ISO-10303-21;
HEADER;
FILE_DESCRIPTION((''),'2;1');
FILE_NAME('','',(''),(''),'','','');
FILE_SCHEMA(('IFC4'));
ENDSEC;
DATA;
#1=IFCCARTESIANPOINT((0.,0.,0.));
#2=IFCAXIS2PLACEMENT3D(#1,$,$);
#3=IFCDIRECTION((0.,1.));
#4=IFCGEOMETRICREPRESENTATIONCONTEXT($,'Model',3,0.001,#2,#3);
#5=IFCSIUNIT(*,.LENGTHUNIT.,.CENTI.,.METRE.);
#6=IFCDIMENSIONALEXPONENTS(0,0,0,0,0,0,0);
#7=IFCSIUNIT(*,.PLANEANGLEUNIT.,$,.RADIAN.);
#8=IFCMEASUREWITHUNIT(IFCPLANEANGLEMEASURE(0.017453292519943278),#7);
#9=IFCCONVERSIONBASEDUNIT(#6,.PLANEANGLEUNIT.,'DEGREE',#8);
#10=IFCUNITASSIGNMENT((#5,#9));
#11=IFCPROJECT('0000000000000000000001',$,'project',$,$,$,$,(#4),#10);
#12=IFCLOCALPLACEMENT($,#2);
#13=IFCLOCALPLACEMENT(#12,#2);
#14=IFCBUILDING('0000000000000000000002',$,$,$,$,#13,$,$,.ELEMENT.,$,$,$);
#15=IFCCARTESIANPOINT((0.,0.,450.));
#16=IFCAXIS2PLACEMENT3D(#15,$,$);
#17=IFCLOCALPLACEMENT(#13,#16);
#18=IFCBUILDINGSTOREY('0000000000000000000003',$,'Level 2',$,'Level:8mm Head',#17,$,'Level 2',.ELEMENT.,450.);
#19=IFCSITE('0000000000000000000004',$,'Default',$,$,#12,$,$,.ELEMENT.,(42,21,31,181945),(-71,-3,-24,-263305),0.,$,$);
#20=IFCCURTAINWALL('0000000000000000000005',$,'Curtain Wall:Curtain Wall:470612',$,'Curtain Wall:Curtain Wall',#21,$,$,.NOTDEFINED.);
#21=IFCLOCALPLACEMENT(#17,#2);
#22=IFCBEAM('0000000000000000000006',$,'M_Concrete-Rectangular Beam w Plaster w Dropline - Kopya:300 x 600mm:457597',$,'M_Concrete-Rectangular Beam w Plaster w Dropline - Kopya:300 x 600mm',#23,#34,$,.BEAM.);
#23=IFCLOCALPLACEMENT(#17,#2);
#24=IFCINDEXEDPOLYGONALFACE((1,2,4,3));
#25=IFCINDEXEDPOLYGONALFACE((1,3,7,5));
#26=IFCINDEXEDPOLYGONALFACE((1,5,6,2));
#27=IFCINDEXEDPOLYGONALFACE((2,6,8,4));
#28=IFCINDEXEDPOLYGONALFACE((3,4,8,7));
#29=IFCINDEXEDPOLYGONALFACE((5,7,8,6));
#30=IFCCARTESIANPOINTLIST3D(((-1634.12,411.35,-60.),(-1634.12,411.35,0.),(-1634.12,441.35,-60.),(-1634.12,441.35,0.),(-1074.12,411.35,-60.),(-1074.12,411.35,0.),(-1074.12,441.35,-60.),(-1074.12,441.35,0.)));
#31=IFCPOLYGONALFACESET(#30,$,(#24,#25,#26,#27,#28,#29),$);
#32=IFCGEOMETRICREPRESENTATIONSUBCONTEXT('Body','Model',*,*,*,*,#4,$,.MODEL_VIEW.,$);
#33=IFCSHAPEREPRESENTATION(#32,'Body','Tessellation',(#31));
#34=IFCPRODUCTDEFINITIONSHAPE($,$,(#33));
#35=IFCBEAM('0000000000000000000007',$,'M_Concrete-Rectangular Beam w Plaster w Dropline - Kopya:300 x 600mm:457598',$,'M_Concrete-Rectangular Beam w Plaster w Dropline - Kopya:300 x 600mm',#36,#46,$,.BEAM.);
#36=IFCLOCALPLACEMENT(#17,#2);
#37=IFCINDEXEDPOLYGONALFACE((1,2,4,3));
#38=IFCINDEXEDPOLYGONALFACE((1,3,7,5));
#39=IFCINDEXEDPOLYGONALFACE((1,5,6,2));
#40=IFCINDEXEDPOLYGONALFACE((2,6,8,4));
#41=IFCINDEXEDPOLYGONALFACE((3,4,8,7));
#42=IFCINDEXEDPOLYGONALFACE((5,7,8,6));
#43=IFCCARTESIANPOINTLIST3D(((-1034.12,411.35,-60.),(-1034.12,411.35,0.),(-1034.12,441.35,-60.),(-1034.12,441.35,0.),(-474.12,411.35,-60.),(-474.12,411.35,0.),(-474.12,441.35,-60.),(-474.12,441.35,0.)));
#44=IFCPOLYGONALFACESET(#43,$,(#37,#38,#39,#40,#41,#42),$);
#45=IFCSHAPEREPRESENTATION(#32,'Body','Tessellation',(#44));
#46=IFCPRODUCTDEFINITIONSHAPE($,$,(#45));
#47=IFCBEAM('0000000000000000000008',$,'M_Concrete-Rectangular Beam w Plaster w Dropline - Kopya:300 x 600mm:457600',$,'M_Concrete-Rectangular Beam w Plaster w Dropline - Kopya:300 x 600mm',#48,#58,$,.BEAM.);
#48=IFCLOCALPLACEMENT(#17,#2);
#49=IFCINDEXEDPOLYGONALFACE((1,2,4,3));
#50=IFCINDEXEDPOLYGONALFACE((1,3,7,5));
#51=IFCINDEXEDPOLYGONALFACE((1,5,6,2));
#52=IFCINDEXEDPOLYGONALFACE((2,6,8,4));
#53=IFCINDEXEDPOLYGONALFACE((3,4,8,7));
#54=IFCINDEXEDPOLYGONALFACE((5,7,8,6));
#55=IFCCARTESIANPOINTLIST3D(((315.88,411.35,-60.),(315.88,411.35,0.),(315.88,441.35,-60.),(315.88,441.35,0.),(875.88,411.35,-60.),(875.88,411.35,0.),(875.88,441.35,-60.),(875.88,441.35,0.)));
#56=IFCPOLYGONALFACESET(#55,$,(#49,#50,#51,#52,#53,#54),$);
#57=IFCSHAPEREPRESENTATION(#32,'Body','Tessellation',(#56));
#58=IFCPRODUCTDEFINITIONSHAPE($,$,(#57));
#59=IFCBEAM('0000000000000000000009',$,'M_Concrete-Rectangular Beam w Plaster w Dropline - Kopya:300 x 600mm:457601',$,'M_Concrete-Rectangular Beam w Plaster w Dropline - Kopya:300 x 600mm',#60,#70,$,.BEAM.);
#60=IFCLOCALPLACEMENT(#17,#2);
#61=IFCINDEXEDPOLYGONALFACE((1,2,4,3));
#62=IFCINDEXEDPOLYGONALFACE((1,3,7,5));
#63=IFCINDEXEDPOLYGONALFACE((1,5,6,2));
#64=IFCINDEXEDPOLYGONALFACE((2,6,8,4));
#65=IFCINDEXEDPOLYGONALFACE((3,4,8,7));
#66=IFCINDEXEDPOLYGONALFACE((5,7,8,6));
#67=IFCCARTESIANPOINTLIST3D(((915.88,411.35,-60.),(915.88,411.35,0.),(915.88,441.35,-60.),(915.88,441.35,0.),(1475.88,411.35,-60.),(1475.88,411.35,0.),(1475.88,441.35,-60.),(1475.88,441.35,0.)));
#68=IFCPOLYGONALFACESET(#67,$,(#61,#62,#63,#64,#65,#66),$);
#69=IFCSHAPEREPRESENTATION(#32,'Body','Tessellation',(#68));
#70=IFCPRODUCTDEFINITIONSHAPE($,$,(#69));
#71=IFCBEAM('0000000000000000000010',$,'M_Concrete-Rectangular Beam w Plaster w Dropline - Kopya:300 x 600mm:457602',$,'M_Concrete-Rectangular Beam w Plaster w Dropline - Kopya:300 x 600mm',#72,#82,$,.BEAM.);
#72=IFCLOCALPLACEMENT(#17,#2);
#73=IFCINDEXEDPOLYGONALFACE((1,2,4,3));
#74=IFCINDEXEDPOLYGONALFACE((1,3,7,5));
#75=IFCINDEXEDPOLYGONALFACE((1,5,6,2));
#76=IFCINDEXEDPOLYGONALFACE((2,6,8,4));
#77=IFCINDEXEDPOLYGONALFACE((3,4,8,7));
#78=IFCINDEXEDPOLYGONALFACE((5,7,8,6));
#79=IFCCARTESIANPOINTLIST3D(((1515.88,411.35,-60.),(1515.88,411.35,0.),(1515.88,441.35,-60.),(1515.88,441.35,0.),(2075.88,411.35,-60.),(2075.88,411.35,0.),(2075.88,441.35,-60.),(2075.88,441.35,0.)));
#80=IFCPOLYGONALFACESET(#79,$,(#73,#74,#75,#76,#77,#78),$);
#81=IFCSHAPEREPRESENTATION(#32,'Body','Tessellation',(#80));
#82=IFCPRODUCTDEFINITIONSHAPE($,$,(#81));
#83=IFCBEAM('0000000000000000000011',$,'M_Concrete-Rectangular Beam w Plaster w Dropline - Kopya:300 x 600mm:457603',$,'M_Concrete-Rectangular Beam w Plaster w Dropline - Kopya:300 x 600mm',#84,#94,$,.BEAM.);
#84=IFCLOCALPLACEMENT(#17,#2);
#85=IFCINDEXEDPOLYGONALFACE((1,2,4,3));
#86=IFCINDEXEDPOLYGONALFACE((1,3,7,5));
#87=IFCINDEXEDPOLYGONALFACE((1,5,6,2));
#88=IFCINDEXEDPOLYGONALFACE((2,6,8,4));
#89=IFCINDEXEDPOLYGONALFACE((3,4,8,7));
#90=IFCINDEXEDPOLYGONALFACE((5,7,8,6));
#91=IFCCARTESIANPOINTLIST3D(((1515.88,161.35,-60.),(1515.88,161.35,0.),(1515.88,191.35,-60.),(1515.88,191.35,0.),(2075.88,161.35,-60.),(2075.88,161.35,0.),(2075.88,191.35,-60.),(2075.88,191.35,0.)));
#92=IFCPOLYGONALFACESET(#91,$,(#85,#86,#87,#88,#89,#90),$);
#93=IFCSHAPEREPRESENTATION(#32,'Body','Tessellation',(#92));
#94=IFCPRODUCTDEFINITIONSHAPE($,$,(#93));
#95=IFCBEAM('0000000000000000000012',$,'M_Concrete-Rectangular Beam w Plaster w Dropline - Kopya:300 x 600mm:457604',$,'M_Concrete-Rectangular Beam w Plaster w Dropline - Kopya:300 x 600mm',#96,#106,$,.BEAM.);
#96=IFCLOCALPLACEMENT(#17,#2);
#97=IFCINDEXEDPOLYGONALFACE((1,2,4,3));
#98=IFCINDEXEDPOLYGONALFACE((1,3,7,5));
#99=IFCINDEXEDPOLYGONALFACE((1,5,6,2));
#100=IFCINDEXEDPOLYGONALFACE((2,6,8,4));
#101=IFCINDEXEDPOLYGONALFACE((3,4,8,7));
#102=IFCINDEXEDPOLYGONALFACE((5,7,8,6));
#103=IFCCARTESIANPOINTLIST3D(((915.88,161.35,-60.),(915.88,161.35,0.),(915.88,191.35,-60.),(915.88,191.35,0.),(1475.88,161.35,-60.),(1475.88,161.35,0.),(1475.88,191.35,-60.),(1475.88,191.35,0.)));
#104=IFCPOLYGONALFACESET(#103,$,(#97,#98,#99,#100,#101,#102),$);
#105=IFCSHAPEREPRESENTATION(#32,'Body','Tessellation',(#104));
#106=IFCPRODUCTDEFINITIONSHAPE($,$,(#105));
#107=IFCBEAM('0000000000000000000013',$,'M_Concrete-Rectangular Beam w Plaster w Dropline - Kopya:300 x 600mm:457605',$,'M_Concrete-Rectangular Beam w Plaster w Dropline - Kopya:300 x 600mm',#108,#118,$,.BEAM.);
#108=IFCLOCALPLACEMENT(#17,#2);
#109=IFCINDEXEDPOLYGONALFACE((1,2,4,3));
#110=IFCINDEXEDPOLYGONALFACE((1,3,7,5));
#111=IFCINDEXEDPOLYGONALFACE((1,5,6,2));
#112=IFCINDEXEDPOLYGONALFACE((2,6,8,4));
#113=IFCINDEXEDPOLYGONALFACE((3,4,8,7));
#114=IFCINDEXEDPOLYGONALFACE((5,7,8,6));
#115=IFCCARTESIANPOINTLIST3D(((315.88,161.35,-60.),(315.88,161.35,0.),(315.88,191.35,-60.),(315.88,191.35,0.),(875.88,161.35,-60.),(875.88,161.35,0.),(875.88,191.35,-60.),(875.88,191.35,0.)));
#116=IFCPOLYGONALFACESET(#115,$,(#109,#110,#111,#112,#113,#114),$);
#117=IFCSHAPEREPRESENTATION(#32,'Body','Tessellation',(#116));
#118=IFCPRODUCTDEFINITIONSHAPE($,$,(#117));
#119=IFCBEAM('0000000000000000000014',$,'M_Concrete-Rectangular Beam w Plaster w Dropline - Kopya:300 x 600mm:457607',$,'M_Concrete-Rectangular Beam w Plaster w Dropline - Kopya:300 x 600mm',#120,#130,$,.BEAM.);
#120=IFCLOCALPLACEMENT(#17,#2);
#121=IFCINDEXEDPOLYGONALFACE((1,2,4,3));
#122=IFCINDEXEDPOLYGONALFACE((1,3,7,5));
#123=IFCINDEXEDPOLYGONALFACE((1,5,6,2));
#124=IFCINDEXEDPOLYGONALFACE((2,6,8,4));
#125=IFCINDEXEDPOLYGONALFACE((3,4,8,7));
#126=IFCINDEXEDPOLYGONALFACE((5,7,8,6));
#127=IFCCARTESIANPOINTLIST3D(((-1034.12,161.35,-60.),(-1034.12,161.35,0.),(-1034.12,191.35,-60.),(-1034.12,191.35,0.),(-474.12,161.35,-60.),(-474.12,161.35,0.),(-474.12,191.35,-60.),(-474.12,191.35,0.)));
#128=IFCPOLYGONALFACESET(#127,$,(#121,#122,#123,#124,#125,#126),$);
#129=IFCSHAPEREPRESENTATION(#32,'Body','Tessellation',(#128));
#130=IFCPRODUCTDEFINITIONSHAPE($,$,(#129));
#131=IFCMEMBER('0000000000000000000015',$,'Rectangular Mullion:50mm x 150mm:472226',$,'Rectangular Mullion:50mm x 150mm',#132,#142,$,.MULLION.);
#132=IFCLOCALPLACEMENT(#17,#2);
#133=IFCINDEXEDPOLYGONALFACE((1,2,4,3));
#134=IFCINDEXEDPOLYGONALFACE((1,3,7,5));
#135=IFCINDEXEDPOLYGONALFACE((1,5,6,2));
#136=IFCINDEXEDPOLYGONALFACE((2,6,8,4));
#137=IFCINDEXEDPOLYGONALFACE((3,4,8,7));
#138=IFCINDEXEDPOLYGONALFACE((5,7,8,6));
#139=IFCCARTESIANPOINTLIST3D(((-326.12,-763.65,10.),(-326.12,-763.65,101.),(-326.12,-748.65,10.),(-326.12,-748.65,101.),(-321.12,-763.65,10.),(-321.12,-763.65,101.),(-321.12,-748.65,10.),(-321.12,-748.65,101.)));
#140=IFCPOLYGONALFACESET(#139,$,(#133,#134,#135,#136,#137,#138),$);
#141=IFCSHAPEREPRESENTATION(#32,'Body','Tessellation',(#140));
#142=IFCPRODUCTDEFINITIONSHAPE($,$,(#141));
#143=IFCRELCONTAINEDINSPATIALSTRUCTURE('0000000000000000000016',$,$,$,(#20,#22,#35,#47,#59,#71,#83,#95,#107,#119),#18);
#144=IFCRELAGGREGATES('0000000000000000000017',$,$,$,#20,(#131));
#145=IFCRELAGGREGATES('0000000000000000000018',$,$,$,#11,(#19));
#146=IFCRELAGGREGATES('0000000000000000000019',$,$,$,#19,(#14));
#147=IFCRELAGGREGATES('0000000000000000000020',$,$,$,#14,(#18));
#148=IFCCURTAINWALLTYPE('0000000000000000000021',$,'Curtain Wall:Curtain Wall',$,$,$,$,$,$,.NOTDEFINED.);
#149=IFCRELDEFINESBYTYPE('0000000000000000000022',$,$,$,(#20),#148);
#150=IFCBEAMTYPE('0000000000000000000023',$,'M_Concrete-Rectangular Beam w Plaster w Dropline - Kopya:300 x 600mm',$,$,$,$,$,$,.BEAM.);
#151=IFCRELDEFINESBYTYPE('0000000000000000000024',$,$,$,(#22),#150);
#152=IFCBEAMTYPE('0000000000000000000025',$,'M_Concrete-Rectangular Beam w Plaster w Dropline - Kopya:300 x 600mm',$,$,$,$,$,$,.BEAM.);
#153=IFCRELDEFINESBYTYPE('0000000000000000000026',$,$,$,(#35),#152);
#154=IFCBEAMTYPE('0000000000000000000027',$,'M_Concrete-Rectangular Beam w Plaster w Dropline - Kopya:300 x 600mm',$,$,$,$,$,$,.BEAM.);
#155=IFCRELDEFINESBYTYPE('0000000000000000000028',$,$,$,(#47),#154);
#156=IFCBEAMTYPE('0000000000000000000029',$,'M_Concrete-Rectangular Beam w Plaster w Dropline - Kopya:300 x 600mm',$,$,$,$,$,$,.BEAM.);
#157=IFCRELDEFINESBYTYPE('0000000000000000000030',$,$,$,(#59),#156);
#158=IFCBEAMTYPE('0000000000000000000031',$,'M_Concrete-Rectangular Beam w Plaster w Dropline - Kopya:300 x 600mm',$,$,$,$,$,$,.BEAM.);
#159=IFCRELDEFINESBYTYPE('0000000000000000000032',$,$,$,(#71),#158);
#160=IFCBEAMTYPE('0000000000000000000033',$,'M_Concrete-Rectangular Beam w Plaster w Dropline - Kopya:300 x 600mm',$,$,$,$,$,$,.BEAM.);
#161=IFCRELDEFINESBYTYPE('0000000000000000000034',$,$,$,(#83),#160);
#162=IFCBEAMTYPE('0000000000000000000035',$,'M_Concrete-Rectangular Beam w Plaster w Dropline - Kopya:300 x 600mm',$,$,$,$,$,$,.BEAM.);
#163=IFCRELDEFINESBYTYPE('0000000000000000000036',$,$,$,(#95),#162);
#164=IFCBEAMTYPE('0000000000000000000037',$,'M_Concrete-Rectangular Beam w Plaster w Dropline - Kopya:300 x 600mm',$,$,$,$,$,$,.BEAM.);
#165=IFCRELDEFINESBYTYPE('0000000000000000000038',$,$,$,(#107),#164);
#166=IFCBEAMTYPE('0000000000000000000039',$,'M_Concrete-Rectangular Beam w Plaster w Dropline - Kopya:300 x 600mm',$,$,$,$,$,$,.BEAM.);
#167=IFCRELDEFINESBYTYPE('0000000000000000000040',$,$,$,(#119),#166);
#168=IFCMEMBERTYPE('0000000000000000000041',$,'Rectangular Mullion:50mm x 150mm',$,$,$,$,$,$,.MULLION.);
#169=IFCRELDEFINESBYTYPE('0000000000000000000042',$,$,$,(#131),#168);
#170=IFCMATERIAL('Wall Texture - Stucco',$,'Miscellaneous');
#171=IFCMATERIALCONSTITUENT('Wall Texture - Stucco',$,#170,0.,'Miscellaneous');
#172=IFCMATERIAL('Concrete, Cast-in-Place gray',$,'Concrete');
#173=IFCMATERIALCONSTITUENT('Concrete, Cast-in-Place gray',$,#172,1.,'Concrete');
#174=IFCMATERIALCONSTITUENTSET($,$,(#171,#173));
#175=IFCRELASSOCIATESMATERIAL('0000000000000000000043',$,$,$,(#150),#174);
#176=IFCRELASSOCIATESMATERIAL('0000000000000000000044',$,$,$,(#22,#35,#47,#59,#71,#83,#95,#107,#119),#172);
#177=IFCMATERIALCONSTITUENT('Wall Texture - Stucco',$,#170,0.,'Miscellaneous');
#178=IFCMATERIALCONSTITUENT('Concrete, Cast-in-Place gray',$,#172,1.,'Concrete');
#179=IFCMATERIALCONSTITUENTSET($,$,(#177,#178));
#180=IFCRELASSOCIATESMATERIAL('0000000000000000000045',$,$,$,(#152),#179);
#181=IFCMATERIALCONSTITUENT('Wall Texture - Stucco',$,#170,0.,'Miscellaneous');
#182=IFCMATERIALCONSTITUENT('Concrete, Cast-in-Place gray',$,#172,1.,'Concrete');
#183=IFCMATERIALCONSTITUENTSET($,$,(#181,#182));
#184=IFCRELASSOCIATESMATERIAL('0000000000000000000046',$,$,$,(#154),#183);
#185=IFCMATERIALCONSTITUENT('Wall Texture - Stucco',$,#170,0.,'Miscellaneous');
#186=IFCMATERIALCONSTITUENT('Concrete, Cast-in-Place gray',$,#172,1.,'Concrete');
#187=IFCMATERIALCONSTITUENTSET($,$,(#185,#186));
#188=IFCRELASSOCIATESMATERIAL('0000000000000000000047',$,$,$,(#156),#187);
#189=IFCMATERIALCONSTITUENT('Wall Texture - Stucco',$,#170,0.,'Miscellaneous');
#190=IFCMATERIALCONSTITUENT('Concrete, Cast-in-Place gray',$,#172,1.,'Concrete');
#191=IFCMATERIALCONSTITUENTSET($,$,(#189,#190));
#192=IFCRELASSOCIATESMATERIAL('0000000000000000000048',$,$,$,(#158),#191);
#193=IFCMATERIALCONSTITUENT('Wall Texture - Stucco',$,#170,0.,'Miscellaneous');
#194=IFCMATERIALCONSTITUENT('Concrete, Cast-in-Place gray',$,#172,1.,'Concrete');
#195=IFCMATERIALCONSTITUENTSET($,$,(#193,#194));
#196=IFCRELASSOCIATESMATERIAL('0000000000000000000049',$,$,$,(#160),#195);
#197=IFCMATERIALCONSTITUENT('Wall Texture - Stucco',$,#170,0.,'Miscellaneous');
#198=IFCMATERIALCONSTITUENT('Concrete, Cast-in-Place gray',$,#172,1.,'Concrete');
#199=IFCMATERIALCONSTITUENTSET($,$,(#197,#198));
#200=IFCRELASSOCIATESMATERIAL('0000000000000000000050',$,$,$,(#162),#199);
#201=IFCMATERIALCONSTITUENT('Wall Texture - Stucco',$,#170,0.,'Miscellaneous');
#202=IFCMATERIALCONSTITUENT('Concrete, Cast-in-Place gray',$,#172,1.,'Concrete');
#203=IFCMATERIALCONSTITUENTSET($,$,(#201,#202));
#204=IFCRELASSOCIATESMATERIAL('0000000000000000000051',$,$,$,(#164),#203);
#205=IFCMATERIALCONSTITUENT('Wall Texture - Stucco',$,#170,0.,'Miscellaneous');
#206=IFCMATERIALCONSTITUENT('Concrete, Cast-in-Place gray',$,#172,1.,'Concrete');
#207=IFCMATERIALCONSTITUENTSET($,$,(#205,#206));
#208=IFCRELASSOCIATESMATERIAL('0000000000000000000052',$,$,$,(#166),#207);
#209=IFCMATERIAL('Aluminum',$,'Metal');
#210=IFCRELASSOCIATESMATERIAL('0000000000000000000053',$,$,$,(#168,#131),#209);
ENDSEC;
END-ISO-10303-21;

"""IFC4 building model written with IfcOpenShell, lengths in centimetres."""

from ifc_helpers import new_model, entity, si_unit, converted_unit, direction, frame, origin, place, context, subcontext, project, spatial, indexed_curve, outline, extrude, source, transform, mapped, material, constituent, constituent_set, type_object, type_shapes, element, aggregate, save


model = new_model("IFC4")

# Units and contexts
model_context = context("Model", 3, precision=0.001, world=origin(), true_north=direction((0.0, 1.0)))
body_context = subcontext(model_context, "Body", "Model", "MODEL_VIEW")
ifc_project = project(units=[si_unit("LENGTHUNIT", "METRE", prefix="CENTI"), converted_unit("PLANEANGLEUNIT", "DEGREE", entity("IfcPlaneAngleMeasure", 0.017453292519943278), si_unit("PLANEANGLEUNIT", "RADIAN"), dimensions=[0, 0, 0, 0, 0, 0, 0])], contexts=[model_context])

# Site, building, storey
site_placement = place(None, origin())
site = spatial("IfcSite", under=ifc_project, at=site_placement, Name="Default", CompositionType="ELEMENT", RefLatitude=(42, 21, 31, 181945), RefLongitude=(-71, -3, -24, -263305), RefElevation=0.0)
building_placement = place(site_placement, origin())
building = spatial("IfcBuilding", under=site, at=building_placement, CompositionType="ELEMENT")
storey_placement = place(building_placement, frame((0.0, 0.0, 450.0)))
storey = spatial("IfcBuildingStorey", under=building, at=storey_placement, Name="Level 2", ObjectType="Level:8mm Head", LongName="Level 2", CompositionType="ELEMENT", Elevation=450.0)

# Curtain wall
curtain_wall_type = type_object("IfcCurtainWallType", Name="Curtain Wall:Curtain Wall", PredefinedType="NOTDEFINED")
curtain_wall_placement = place(storey_placement, frame((0.0, 0.0, -450.0)))
curtain_wall = element("IfcCurtainWall", 1, at=curtain_wall_placement, inside=storey, type_object=curtain_wall_type, Name="Curtain Wall:Curtain Wall:470612", ObjectType="Curtain Wall:Curtain Wall", PredefinedType="NOTDEFINED")
ifc_material_1 = material(Name="Aluminum", Category="Metal")

# Beams
ifc_material_2 = material(Name="Concrete, Cast-in-Place gray", Category="Concrete")
ifc_material_3 = material(Name="Wall Texture - Stucco", Category="Miscellaneous")
ifc_constituent_1 = constituent(ifc_material_3, Name="Wall Texture - Stucco", Category="Miscellaneous", fraction=0.0)
ifc_constituent_2 = constituent(ifc_material_2, Name="Concrete, Cast-in-Place gray", Category="Concrete", fraction=1.0)
ifc_constituent_set_1 = constituent_set(constituents=[ifc_constituent_1, ifc_constituent_2])
beam_type_1 = type_object("IfcBeamType", Name="M_Concrete-Rectangular Beam w Plaster w Dropline - Kopya:300 x 600mm", PredefinedType="BEAM", material=ifc_constituent_set_1)
shared_shape_1 = source(origin(), body_context, "Body", "SweptSolid", [
    extrude(outline(indexed_curve([(-30.0, -15.0), (30.0, -15.0), (30.0, 15.0), (-30.0, 15.0), (-30.0, -15.0)], self_intersect=False)), frame((-1634.12, 426.35, 420.0), z_axis=(1.0, 0.0, 0.0), x_axis=(0.0, 0.0, -1.0)), (0.0, 0.0, 1.0), 560.0),
])
type_shapes(beam_type_1, [shared_shape_1])
beam_1_placement = place(storey_placement, frame((0.0, 0.0, -450.0)))
element("IfcBeam", 2, at=beam_1_placement, inside=storey, type_object=beam_type_1, material=ifc_material_2, Name="M_Concrete-Rectangular Beam w Plaster w Dropline - Kopya:300 x 600mm:457597", ObjectType="M_Concrete-Rectangular Beam w Plaster w Dropline - Kopya:300 x 600mm", PredefinedType="BEAM", context=body_context, shape_type="MappedRepresentation", body=[
    mapped(shared_shape_1, transform((0.0, 0.0, 0.0), scale=1.0)),
])
ifc_constituent_3 = constituent(ifc_material_3, Name="Wall Texture - Stucco", Category="Miscellaneous", fraction=0.0)
ifc_constituent_4 = constituent(ifc_material_2, Name="Concrete, Cast-in-Place gray", Category="Concrete", fraction=1.0)
ifc_constituent_set_2 = constituent_set(constituents=[ifc_constituent_3, ifc_constituent_4])
beam_type_2 = type_object("IfcBeamType", Name="M_Concrete-Rectangular Beam w Plaster w Dropline - Kopya:300 x 600mm", PredefinedType="BEAM", material=ifc_constituent_set_2)
shared_shape_2 = source(origin(), body_context, "Body", "SweptSolid", [
    extrude(outline(indexed_curve([(-30.0, -15.0), (30.0, -15.0), (30.0, 15.0), (-30.0, 15.0), (-30.0, -15.0)], self_intersect=False)), frame((-1034.12, 426.35, 420.0), z_axis=(1.0, 0.0, 0.0), x_axis=(0.0, 0.0, -1.0)), (0.0, 0.0, 1.0), 560.0),
])
type_shapes(beam_type_2, [shared_shape_2])
beam_2_placement = place(storey_placement, frame((0.0, 0.0, -450.0)))
element("IfcBeam", 3, at=beam_2_placement, inside=storey, type_object=beam_type_2, material=ifc_material_2, Name="M_Concrete-Rectangular Beam w Plaster w Dropline - Kopya:300 x 600mm:457598", ObjectType="M_Concrete-Rectangular Beam w Plaster w Dropline - Kopya:300 x 600mm", PredefinedType="BEAM", context=body_context, shape_type="MappedRepresentation", body=[
    mapped(shared_shape_2, transform((0.0, 0.0, 0.0), scale=1.0)),
])
ifc_constituent_5 = constituent(ifc_material_3, Name="Wall Texture - Stucco", Category="Miscellaneous", fraction=0.0)
ifc_constituent_6 = constituent(ifc_material_2, Name="Concrete, Cast-in-Place gray", Category="Concrete", fraction=1.0)
ifc_constituent_set_3 = constituent_set(constituents=[ifc_constituent_5, ifc_constituent_6])
beam_type_3 = type_object("IfcBeamType", Name="M_Concrete-Rectangular Beam w Plaster w Dropline - Kopya:300 x 600mm", PredefinedType="BEAM", material=ifc_constituent_set_3)
shared_shape_3 = source(origin(), body_context, "Body", "SweptSolid", [
    extrude(outline(indexed_curve([(-30.0, -15.0), (30.0, -15.0), (30.0, 15.0), (-30.0, 15.0), (-30.0, -15.0)], self_intersect=False)), frame((315.88, 426.35, 420.0), z_axis=(1.0, 0.0, 0.0), x_axis=(0.0, 0.0, -1.0)), (0.0, 0.0, 1.0), 560.0),
])
type_shapes(beam_type_3, [shared_shape_3])
beam_3_placement = place(storey_placement, frame((0.0, 0.0, -450.0)))
element("IfcBeam", 4, at=beam_3_placement, inside=storey, type_object=beam_type_3, material=ifc_material_2, Name="M_Concrete-Rectangular Beam w Plaster w Dropline - Kopya:300 x 600mm:457600", ObjectType="M_Concrete-Rectangular Beam w Plaster w Dropline - Kopya:300 x 600mm", PredefinedType="BEAM", context=body_context, shape_type="MappedRepresentation", body=[
    mapped(shared_shape_3, transform((0.0, 0.0, 0.0), scale=1.0)),
])
ifc_constituent_7 = constituent(ifc_material_3, Name="Wall Texture - Stucco", Category="Miscellaneous", fraction=0.0)
ifc_constituent_8 = constituent(ifc_material_2, Name="Concrete, Cast-in-Place gray", Category="Concrete", fraction=1.0)
ifc_constituent_set_4 = constituent_set(constituents=[ifc_constituent_7, ifc_constituent_8])
beam_type_4 = type_object("IfcBeamType", Name="M_Concrete-Rectangular Beam w Plaster w Dropline - Kopya:300 x 600mm", PredefinedType="BEAM", material=ifc_constituent_set_4)
shared_shape_4 = source(origin(), body_context, "Body", "SweptSolid", [
    extrude(outline(indexed_curve([(-30.0, -15.0), (30.0, -15.0), (30.0, 15.0), (-30.0, 15.0), (-30.0, -15.0)], self_intersect=False)), frame((915.88, 426.35, 420.0), z_axis=(1.0, 0.0, 0.0), x_axis=(0.0, 0.0, -1.0)), (0.0, 0.0, 1.0), 560.0),
])
type_shapes(beam_type_4, [shared_shape_4])
beam_4_placement = place(storey_placement, frame((0.0, 0.0, -450.0)))
element("IfcBeam", 5, at=beam_4_placement, inside=storey, type_object=beam_type_4, material=ifc_material_2, Name="M_Concrete-Rectangular Beam w Plaster w Dropline - Kopya:300 x 600mm:457601", ObjectType="M_Concrete-Rectangular Beam w Plaster w Dropline - Kopya:300 x 600mm", PredefinedType="BEAM", context=body_context, shape_type="MappedRepresentation", body=[
    mapped(shared_shape_4, transform((0.0, 0.0, 0.0), scale=1.0)),
])
ifc_constituent_9 = constituent(ifc_material_3, Name="Wall Texture - Stucco", Category="Miscellaneous", fraction=0.0)
ifc_constituent_10 = constituent(ifc_material_2, Name="Concrete, Cast-in-Place gray", Category="Concrete", fraction=1.0)
ifc_constituent_set_5 = constituent_set(constituents=[ifc_constituent_9, ifc_constituent_10])
beam_type_5 = type_object("IfcBeamType", Name="M_Concrete-Rectangular Beam w Plaster w Dropline - Kopya:300 x 600mm", PredefinedType="BEAM", material=ifc_constituent_set_5)
shared_shape_5 = source(origin(), body_context, "Body", "SweptSolid", [
    extrude(outline(indexed_curve([(-30.0, -15.0), (30.0, -15.0), (30.0, 15.0), (-30.0, 15.0), (-30.0, -15.0)], self_intersect=False)), frame((1515.88, 426.35, 420.0), z_axis=(1.0, 0.0, 0.0), x_axis=(0.0, 0.0, -1.0)), (0.0, 0.0, 1.0), 560.0),
])
type_shapes(beam_type_5, [shared_shape_5])
beam_5_placement = place(storey_placement, frame((0.0, 0.0, -450.0)))
element("IfcBeam", 6, at=beam_5_placement, inside=storey, type_object=beam_type_5, material=ifc_material_2, Name="M_Concrete-Rectangular Beam w Plaster w Dropline - Kopya:300 x 600mm:457602", ObjectType="M_Concrete-Rectangular Beam w Plaster w Dropline - Kopya:300 x 600mm", PredefinedType="BEAM", context=body_context, shape_type="MappedRepresentation", body=[
    mapped(shared_shape_5, transform((0.0, 0.0, 0.0), scale=1.0)),
])
ifc_constituent_11 = constituent(ifc_material_3, Name="Wall Texture - Stucco", Category="Miscellaneous", fraction=0.0)
ifc_constituent_12 = constituent(ifc_material_2, Name="Concrete, Cast-in-Place gray", Category="Concrete", fraction=1.0)
ifc_constituent_set_6 = constituent_set(constituents=[ifc_constituent_11, ifc_constituent_12])
beam_type_6 = type_object("IfcBeamType", Name="M_Concrete-Rectangular Beam w Plaster w Dropline - Kopya:300 x 600mm", PredefinedType="BEAM", material=ifc_constituent_set_6)
shared_shape_6 = source(origin(), body_context, "Body", "SweptSolid", [
    extrude(outline(indexed_curve([(-30.0, -15.0), (30.0, -15.0), (30.0, 15.0), (-30.0, 15.0), (-30.0, -15.0)], self_intersect=False)), frame((2075.88, 176.35, 420.0), z_axis=(-1.0, 0.0, 0.0), x_axis=(0.0, 0.0, -1.0)), (0.0, 0.0, 1.0), 560.0),
])
type_shapes(beam_type_6, [shared_shape_6])
beam_6_placement = place(storey_placement, frame((0.0, 0.0, -450.0)))
element("IfcBeam", 7, at=beam_6_placement, inside=storey, type_object=beam_type_6, material=ifc_material_2, Name="M_Concrete-Rectangular Beam w Plaster w Dropline - Kopya:300 x 600mm:457603", ObjectType="M_Concrete-Rectangular Beam w Plaster w Dropline - Kopya:300 x 600mm", PredefinedType="BEAM", context=body_context, shape_type="MappedRepresentation", body=[
    mapped(shared_shape_6, transform((0.0, 0.0, 0.0), scale=1.0)),
])
ifc_constituent_13 = constituent(ifc_material_3, Name="Wall Texture - Stucco", Category="Miscellaneous", fraction=0.0)
ifc_constituent_14 = constituent(ifc_material_2, Name="Concrete, Cast-in-Place gray", Category="Concrete", fraction=1.0)
ifc_constituent_set_7 = constituent_set(constituents=[ifc_constituent_13, ifc_constituent_14])
beam_type_7 = type_object("IfcBeamType", Name="M_Concrete-Rectangular Beam w Plaster w Dropline - Kopya:300 x 600mm", PredefinedType="BEAM", material=ifc_constituent_set_7)
shared_shape_7 = source(origin(), body_context, "Body", "SweptSolid", [
    extrude(outline(indexed_curve([(-30.0, -15.0), (30.0, -15.0), (30.0, 15.0), (-30.0, 15.0), (-30.0, -15.0)], self_intersect=False)), frame((1475.88, 176.35, 420.0), z_axis=(-1.0, 0.0, 0.0), x_axis=(0.0, 0.0, -1.0)), (0.0, 0.0, 1.0), 560.0),
])
type_shapes(beam_type_7, [shared_shape_7])
beam_7_placement = place(storey_placement, frame((0.0, 0.0, -450.0)))
element("IfcBeam", 8, at=beam_7_placement, inside=storey, type_object=beam_type_7, material=ifc_material_2, Name="M_Concrete-Rectangular Beam w Plaster w Dropline - Kopya:300 x 600mm:457604", ObjectType="M_Concrete-Rectangular Beam w Plaster w Dropline - Kopya:300 x 600mm", PredefinedType="BEAM", context=body_context, shape_type="MappedRepresentation", body=[
    mapped(shared_shape_7, transform((0.0, 0.0, 0.0), scale=1.0)),
])
ifc_constituent_15 = constituent(ifc_material_3, Name="Wall Texture - Stucco", Category="Miscellaneous", fraction=0.0)
ifc_constituent_16 = constituent(ifc_material_2, Name="Concrete, Cast-in-Place gray", Category="Concrete", fraction=1.0)
ifc_constituent_set_8 = constituent_set(constituents=[ifc_constituent_15, ifc_constituent_16])
beam_type_8 = type_object("IfcBeamType", Name="M_Concrete-Rectangular Beam w Plaster w Dropline - Kopya:300 x 600mm", PredefinedType="BEAM", material=ifc_constituent_set_8)
shared_shape_8 = source(origin(), body_context, "Body", "SweptSolid", [
    extrude(outline(indexed_curve([(-30.0, -15.0), (30.0, -15.0), (30.0, 15.0), (-30.0, 15.0), (-30.0, -15.0)], self_intersect=False)), frame((875.88, 176.35, 420.0), z_axis=(-1.0, 0.0, 0.0), x_axis=(0.0, 0.0, -1.0)), (0.0, 0.0, 1.0), 560.0),
])
type_shapes(beam_type_8, [shared_shape_8])
beam_8_placement = place(storey_placement, frame((0.0, 0.0, -450.0)))
element("IfcBeam", 9, at=beam_8_placement, inside=storey, type_object=beam_type_8, material=ifc_material_2, Name="M_Concrete-Rectangular Beam w Plaster w Dropline - Kopya:300 x 600mm:457605", ObjectType="M_Concrete-Rectangular Beam w Plaster w Dropline - Kopya:300 x 600mm", PredefinedType="BEAM", context=body_context, shape_type="MappedRepresentation", body=[
    mapped(shared_shape_8, transform((0.0, 0.0, 0.0), scale=1.0)),
])
ifc_constituent_17 = constituent(ifc_material_3, Name="Wall Texture - Stucco", Category="Miscellaneous", fraction=0.0)
ifc_constituent_18 = constituent(ifc_material_2, Name="Concrete, Cast-in-Place gray", Category="Concrete", fraction=1.0)
ifc_constituent_set_9 = constituent_set(constituents=[ifc_constituent_17, ifc_constituent_18])
beam_type_9 = type_object("IfcBeamType", Name="M_Concrete-Rectangular Beam w Plaster w Dropline - Kopya:300 x 600mm", PredefinedType="BEAM", material=ifc_constituent_set_9)
shared_shape_9 = source(origin(), body_context, "Body", "SweptSolid", [
    extrude(outline(indexed_curve([(-30.0, -15.0), (30.0, -15.0), (30.0, 15.0), (-30.0, 15.0), (-30.0, -15.0)], self_intersect=False)), frame((-474.12, 176.35, 420.0), z_axis=(-1.0, 0.0, 0.0), x_axis=(0.0, 0.0, -1.0)), (0.0, 0.0, 1.0), 560.0),
])
type_shapes(beam_type_9, [shared_shape_9])
beam_9_placement = place(storey_placement, frame((0.0, 0.0, -450.0)))
element("IfcBeam", 10, at=beam_9_placement, inside=storey, type_object=beam_type_9, material=ifc_material_2, Name="M_Concrete-Rectangular Beam w Plaster w Dropline - Kopya:300 x 600mm:457607", ObjectType="M_Concrete-Rectangular Beam w Plaster w Dropline - Kopya:300 x 600mm", PredefinedType="BEAM", context=body_context, shape_type="MappedRepresentation", body=[
    mapped(shared_shape_9, transform((0.0, 0.0, 0.0), scale=1.0)),
])

# Member
member_type_1 = type_object("IfcMemberType", Name="Rectangular Mullion:50mm x 150mm", PredefinedType="MULLION", material=ifc_material_1)
shared_shape_10 = source(origin(), body_context, "Body", "SweptSolid", [
    extrude(outline(indexed_curve([(-2.5, -7.5), (2.5, -7.5), (2.5, 7.5), (-2.5, 7.5), (-2.5, -7.5)], self_intersect=False)), frame((0.0, 0.0, -91.0), z_axis=(0.0, 0.0, 1.0), x_axis=(-1.0, 0.0, 0.0)), (0.0, 0.0, 1.0), 91.0),
])
type_shapes(member_type_1, [shared_shape_10])
member_1_placement = place(curtain_wall_placement, frame((-323.62, -756.15, 460.0), z_axis=(0.0, 0.0, -1.0), x_axis=(1.0, 0.0, 0.0)))
member_1 = element("IfcMember", 11, at=member_1_placement, type_object=member_type_1, material=ifc_material_1, Name="Rectangular Mullion:50mm x 150mm:472226", ObjectType="Rectangular Mullion:50mm x 150mm", PredefinedType="MULLION", context=body_context, shape_type="MappedRepresentation", body=[
    mapped(shared_shape_10, transform((0.0, 0.0, 0.0), scale=1.0)),
])

aggregate(curtain_wall, [member_1])

save(model, "model.ifc")
